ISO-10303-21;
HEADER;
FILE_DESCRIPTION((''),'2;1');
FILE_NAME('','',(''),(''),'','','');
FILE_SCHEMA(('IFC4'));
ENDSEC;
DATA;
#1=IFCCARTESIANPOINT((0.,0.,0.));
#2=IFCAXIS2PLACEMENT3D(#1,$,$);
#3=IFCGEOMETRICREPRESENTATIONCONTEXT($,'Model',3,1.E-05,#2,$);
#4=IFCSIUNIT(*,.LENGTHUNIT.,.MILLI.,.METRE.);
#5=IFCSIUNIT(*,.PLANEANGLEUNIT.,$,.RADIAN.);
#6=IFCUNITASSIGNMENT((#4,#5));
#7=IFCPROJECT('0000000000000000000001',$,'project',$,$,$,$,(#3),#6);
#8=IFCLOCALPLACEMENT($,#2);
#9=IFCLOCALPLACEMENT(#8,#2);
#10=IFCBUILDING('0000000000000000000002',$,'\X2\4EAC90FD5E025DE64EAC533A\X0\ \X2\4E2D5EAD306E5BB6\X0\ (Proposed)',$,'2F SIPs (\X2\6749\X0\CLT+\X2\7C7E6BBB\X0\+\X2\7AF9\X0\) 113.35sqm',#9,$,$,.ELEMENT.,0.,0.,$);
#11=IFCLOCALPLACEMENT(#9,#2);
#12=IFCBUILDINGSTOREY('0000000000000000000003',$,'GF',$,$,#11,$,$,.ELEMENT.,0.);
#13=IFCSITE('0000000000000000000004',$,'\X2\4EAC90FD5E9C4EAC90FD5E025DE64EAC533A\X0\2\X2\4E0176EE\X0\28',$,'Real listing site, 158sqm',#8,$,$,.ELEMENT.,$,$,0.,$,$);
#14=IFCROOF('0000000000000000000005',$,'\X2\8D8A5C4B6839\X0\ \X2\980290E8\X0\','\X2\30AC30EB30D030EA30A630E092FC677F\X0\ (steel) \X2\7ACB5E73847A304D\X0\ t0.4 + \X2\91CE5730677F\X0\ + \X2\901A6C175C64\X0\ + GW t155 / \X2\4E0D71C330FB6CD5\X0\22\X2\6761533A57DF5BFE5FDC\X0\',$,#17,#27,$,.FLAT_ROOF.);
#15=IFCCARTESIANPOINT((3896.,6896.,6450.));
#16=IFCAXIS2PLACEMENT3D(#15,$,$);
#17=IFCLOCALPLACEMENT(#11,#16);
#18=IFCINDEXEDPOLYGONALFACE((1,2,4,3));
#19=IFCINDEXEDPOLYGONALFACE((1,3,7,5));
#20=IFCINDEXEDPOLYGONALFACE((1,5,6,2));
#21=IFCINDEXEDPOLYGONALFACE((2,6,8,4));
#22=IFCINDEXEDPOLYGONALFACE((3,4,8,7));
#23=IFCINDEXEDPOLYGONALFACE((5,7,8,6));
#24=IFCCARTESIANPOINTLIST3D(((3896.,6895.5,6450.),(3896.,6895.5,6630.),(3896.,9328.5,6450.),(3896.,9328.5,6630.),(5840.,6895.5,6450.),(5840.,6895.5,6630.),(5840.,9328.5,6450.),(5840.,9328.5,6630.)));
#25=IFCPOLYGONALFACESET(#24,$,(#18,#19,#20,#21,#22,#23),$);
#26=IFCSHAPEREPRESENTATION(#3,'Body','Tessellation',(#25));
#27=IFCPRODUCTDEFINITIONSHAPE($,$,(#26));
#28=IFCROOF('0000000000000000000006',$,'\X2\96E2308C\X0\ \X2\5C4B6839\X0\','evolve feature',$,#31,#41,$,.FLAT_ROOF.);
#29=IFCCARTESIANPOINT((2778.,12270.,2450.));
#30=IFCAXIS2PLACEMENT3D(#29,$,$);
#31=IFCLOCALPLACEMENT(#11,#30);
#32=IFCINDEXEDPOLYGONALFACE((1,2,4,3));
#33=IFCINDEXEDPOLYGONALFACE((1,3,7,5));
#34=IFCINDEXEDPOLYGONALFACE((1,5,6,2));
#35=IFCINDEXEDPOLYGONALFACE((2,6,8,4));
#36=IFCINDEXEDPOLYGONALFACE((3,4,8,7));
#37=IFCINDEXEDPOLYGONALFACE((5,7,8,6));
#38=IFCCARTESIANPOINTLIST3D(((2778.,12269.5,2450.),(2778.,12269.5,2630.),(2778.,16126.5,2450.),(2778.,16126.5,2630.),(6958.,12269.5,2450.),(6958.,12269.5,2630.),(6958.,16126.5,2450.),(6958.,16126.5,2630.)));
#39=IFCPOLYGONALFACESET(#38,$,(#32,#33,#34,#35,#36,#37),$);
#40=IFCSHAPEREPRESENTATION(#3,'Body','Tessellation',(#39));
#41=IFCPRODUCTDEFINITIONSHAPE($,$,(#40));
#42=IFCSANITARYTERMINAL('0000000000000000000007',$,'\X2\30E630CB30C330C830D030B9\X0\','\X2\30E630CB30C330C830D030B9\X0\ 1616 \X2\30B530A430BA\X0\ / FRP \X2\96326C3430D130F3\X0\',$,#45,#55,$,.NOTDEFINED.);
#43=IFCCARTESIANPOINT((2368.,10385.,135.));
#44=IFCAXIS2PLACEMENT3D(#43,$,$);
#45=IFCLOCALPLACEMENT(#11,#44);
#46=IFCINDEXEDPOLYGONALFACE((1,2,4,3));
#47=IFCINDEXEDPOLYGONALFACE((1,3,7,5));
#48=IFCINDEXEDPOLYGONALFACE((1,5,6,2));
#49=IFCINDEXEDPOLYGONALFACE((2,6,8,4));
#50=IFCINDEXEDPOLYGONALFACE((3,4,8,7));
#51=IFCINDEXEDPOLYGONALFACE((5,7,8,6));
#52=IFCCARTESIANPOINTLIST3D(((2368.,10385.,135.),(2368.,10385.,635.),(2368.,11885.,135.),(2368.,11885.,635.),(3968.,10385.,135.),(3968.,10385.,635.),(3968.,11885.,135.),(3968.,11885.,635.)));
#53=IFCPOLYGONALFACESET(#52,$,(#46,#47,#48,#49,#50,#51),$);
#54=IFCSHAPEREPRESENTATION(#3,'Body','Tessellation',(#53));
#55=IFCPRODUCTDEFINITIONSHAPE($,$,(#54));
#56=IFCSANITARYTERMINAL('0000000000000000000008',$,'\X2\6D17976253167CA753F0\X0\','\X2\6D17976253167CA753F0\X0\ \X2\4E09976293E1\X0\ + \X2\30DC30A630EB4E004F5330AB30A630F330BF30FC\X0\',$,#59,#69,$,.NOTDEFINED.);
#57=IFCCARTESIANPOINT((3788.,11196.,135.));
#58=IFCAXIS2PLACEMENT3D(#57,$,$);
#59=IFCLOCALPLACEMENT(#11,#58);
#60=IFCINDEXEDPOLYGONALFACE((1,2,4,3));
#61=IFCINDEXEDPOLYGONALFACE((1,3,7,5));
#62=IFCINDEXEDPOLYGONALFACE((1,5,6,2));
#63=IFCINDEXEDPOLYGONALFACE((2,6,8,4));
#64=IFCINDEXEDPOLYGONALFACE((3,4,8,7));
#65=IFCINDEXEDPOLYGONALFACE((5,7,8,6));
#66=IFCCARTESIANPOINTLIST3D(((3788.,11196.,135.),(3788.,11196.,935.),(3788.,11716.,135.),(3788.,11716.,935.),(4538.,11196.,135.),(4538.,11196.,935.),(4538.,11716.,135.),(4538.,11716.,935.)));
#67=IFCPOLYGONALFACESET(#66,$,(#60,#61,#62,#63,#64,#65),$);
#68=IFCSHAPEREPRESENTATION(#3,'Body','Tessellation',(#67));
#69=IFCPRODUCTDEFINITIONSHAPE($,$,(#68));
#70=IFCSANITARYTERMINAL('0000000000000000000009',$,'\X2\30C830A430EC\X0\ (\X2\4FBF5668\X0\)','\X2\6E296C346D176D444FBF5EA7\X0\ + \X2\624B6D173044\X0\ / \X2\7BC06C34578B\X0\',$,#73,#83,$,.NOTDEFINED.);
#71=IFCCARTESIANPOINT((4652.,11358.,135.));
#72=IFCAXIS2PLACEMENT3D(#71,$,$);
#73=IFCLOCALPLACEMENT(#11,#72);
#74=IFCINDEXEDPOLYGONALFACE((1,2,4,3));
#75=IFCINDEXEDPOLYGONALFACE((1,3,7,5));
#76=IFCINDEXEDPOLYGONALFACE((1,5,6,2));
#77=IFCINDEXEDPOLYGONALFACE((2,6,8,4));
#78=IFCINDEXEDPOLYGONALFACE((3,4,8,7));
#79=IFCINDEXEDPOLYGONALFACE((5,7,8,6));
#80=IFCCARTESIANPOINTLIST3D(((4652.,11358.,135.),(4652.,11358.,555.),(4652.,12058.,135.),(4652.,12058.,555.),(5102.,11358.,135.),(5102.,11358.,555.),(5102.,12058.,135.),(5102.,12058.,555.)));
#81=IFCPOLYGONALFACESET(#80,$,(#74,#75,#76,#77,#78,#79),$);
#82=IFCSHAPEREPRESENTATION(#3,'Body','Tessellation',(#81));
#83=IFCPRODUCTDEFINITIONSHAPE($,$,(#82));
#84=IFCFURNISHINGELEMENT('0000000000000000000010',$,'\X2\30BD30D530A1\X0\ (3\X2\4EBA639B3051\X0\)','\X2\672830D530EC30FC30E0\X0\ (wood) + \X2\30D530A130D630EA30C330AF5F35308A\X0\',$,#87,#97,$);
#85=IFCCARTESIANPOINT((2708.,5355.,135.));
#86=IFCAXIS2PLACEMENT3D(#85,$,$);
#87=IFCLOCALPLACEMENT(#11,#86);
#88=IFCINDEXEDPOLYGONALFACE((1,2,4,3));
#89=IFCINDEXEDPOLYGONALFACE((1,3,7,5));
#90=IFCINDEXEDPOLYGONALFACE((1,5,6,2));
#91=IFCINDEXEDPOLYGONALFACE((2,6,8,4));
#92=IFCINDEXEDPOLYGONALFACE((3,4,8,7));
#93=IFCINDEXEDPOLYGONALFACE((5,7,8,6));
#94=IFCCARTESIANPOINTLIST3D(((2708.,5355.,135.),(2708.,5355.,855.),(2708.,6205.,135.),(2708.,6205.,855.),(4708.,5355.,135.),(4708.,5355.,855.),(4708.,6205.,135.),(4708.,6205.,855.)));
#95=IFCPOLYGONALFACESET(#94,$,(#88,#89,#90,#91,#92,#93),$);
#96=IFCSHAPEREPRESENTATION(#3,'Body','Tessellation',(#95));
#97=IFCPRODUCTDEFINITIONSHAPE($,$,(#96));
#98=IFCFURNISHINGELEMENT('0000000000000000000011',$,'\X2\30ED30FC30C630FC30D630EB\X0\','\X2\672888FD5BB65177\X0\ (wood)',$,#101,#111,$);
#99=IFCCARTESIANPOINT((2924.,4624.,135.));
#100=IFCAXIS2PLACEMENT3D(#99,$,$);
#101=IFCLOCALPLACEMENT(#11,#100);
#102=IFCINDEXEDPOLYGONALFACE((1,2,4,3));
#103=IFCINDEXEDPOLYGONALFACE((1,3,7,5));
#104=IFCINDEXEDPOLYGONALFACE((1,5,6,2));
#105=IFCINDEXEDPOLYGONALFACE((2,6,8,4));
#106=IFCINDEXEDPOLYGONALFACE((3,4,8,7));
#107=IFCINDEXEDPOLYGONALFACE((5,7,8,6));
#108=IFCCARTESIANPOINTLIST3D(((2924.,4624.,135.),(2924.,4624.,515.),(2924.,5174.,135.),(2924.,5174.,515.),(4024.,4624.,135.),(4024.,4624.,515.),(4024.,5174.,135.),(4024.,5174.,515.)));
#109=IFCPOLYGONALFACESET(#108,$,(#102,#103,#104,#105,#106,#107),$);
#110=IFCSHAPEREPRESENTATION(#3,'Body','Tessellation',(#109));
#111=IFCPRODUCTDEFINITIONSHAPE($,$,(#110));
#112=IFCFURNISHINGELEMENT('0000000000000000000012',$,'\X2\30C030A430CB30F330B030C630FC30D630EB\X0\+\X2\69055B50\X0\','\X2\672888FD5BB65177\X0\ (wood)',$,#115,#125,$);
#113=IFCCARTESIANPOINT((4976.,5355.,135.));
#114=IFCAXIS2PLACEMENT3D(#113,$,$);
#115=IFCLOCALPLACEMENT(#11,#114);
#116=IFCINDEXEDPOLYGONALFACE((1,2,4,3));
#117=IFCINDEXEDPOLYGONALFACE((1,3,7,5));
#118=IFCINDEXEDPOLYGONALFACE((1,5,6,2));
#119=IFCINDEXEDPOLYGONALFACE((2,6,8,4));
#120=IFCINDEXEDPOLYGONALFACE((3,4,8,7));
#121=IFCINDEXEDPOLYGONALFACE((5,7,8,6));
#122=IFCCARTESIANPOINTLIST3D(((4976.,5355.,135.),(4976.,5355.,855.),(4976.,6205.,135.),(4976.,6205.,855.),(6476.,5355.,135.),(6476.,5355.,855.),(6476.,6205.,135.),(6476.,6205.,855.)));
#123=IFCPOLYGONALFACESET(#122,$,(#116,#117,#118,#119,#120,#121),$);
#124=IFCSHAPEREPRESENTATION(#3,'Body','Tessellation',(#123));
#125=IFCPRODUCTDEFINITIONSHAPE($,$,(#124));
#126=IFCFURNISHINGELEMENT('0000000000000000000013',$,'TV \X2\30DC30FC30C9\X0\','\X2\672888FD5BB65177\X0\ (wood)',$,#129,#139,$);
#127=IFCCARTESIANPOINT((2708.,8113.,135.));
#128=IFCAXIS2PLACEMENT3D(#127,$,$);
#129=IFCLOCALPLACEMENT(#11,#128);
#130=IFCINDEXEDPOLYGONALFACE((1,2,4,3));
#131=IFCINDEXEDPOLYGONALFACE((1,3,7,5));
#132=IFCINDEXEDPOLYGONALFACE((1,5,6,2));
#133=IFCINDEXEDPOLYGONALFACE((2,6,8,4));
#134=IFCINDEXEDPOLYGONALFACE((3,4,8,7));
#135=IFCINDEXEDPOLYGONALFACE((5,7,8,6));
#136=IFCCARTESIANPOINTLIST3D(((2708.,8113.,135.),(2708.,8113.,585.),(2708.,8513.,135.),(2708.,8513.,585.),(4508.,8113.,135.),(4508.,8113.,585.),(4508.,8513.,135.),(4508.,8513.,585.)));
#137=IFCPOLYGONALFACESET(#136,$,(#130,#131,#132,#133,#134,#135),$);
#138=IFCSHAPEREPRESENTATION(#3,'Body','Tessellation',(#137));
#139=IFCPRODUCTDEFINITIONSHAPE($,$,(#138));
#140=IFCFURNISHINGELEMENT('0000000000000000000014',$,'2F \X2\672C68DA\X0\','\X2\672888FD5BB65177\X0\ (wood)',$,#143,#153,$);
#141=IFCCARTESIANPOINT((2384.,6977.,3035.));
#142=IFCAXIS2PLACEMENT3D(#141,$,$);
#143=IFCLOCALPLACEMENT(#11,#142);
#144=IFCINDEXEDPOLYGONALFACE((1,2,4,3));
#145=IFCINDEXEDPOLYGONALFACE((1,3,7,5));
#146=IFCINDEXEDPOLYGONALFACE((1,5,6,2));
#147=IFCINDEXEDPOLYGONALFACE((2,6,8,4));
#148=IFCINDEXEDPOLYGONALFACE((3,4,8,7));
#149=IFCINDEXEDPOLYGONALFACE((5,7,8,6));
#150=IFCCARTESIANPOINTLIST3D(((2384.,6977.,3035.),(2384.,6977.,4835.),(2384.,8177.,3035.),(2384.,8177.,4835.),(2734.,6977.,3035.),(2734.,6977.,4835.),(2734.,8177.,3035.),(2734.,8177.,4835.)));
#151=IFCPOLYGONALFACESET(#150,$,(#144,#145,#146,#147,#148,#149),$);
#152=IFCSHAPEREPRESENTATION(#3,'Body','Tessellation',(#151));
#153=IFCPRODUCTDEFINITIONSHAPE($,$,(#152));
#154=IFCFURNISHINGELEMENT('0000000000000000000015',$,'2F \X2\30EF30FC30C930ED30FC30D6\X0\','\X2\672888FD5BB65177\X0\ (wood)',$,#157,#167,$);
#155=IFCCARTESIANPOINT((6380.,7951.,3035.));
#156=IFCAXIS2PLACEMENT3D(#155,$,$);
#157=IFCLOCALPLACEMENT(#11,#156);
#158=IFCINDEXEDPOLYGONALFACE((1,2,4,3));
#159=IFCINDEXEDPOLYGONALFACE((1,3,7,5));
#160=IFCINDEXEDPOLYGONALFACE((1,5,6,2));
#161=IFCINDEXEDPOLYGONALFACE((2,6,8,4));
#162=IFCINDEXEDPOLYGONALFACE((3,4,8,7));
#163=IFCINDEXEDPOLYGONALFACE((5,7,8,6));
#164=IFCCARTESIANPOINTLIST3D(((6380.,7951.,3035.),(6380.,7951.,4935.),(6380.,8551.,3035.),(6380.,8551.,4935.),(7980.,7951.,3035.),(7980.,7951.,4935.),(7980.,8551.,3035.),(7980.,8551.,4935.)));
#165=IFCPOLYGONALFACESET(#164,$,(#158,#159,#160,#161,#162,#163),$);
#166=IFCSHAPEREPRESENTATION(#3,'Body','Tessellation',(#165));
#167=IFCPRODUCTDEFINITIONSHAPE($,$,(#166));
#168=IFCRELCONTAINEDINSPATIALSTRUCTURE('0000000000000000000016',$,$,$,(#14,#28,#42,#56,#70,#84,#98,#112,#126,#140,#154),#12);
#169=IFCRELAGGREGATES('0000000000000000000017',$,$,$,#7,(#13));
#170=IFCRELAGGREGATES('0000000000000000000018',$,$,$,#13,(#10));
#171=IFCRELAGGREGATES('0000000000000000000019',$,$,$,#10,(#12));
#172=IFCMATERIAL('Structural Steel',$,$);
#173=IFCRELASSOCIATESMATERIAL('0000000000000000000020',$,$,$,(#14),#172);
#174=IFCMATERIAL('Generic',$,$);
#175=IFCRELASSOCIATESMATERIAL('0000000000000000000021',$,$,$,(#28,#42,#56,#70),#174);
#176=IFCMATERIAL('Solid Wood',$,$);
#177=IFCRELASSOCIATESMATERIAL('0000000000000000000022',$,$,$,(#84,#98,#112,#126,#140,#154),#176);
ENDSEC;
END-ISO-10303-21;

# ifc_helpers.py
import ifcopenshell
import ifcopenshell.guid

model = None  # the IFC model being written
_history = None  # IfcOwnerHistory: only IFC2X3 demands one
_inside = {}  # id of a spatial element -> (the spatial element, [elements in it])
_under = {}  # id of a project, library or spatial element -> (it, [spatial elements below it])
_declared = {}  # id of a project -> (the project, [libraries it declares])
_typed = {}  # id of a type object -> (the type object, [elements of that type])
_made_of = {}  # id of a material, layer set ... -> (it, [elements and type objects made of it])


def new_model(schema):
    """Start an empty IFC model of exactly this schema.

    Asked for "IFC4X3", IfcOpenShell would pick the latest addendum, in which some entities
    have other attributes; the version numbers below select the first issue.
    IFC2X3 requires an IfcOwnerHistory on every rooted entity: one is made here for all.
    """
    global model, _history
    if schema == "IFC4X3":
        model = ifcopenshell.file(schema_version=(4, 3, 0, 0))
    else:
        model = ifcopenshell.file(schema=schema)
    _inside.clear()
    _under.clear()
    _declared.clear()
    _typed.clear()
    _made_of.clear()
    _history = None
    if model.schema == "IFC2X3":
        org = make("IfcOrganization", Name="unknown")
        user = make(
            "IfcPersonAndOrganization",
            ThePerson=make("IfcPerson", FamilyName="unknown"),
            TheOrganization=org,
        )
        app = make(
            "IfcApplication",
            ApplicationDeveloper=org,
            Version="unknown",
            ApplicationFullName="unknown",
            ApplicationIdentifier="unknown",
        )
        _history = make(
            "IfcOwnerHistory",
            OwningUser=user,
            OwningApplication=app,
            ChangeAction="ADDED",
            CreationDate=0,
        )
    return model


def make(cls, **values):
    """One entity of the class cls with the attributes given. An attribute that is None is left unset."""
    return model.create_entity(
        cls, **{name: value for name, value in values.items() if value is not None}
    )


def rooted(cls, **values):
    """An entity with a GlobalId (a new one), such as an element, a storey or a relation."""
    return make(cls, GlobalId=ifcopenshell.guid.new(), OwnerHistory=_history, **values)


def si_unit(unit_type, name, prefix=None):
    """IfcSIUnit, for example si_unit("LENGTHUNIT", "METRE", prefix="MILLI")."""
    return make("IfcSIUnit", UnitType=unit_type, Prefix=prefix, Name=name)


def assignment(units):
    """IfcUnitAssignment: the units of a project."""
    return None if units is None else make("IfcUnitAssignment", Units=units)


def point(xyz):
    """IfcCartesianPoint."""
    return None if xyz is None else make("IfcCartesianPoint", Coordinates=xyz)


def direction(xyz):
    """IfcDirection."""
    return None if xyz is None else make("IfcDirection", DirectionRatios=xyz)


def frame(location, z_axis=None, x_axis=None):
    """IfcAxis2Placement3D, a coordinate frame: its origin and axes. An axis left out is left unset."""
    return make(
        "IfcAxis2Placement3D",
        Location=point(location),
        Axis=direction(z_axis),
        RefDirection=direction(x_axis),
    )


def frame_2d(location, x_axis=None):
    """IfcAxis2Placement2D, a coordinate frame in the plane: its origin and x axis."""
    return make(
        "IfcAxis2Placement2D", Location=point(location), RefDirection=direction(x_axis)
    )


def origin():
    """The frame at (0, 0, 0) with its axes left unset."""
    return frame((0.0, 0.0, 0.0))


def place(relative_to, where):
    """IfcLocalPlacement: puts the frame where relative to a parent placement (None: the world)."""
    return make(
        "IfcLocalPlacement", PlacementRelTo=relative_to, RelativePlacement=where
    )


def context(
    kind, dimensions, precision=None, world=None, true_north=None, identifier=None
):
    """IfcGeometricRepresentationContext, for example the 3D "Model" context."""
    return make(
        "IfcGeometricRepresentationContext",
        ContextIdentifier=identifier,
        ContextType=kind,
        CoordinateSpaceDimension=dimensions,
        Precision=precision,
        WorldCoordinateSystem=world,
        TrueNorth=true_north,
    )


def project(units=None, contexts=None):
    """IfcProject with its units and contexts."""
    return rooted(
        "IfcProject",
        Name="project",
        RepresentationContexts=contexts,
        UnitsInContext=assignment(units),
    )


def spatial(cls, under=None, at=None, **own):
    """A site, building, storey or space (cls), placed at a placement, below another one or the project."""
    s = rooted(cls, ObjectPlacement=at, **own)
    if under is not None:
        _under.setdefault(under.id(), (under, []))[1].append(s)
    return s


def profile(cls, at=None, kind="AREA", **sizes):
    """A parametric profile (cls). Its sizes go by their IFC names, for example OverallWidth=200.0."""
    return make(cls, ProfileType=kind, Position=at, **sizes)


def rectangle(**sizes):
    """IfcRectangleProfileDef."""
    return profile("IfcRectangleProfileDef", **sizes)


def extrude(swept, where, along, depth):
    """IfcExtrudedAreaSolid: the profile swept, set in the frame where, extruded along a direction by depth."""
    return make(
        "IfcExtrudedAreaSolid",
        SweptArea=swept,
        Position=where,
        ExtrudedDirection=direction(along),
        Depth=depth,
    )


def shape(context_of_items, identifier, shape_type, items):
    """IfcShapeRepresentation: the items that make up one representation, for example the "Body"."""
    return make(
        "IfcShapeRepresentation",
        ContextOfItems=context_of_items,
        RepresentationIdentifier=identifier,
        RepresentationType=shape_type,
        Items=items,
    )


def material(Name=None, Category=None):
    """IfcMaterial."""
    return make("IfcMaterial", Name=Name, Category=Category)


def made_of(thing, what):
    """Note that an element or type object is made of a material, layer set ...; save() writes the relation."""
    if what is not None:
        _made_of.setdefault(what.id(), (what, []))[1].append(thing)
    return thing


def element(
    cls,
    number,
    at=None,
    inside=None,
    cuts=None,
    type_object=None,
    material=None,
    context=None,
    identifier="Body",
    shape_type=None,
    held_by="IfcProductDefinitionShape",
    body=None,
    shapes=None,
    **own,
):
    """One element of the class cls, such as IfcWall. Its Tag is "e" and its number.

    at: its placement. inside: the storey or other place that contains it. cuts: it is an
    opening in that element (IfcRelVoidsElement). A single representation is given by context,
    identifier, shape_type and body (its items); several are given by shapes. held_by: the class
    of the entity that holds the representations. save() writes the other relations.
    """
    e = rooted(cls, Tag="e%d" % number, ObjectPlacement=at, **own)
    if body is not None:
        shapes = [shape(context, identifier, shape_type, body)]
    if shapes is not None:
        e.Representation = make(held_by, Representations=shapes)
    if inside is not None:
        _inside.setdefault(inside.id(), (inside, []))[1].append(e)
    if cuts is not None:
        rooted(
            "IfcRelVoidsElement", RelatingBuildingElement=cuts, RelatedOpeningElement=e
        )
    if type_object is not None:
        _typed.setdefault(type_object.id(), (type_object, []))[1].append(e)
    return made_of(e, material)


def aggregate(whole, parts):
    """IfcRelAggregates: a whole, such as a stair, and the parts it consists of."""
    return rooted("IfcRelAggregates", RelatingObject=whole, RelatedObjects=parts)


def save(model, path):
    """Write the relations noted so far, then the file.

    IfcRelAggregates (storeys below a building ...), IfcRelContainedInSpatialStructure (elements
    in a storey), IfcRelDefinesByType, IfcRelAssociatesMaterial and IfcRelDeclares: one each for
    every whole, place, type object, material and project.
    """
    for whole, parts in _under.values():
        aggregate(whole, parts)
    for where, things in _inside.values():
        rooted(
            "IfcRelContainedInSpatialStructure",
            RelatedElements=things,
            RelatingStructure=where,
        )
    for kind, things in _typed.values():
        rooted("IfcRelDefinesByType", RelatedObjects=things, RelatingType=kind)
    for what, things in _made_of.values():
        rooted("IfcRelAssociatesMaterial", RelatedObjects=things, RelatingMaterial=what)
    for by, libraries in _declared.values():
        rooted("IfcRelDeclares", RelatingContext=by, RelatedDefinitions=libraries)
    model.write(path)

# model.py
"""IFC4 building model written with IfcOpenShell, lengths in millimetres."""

from ifc_helpers import new_model, si_unit, frame, frame_2d, origin, place, context, project, spatial, rectangle, extrude, material, element, save


model = new_model("IFC4")

# Units and contexts
model_context = context("Model", 3, precision=1e-05, world=origin())
ifc_project = project(units=[si_unit("LENGTHUNIT", "METRE", prefix="MILLI"), si_unit("PLANEANGLEUNIT", "RADIAN")], contexts=[model_context])

# Site, building, storey
site_placement = place(None, origin())
site = spatial("IfcSite", under=ifc_project, at=site_placement, Name="京都府京都市左京区2丁目28", ObjectType="Real listing site, 158sqm", CompositionType="ELEMENT", RefElevation=0.0)
building_placement = place(site_placement, origin())
building = spatial("IfcBuilding", under=site, at=building_placement, Name="京都市左京区 中庭の家 (Proposed)", ObjectType="2F SIPs (杉CLT+籾殻+竹) 113.35sqm", CompositionType="ELEMENT", ElevationOfRefHeight=0.0, ElevationOfTerrain=0.0)
storey_placement = place(building_placement, origin())
storey = spatial("IfcBuildingStorey", under=building, at=storey_placement, Name="GF", CompositionType="ELEMENT", Elevation=0.0)

# Shared definitions
ifc_material_1 = material(Name="Generic")

# Shared definitions
ifc_material_2 = material(Name="Solid Wood")

# Roofs
ifc_material_3 = material(Name="Structural Steel")
roof_1_placement = place(storey_placement, frame((3896.0, 6896.0, 6450.0)))
element("IfcRoof", 1, at=roof_1_placement, inside=storey, material=ifc_material_3, Name="越屋根 頂部", Description="ガルバリウム鋼板 (steel) 立平葺き t0.4 + 野地板 + 通気層 + GW t155 / 不燃・法22条区域対応", PredefinedType="FLAT_ROOF", context=model_context, shape_type="SweptSolid", body=[
    extrude(rectangle(XDim=1944.0, YDim=2433.0, at=frame_2d((972.0, 1216.0))), frame((3896.0, 6896.0, 6450.0)), (0.0, 0.0, 1.0), 180.0),
])
roof_2_placement = place(storey_placement, frame((2778.0, 12270.0, 2450.0)))
element("IfcRoof", 2, at=roof_2_placement, inside=storey, material=ifc_material_1, Name="離れ 屋根", Description="evolve feature", PredefinedType="FLAT_ROOF", context=model_context, shape_type="SweptSolid", body=[
    extrude(rectangle(XDim=4180.0, YDim=3857.0, at=frame_2d((2090.0, 1928.0))), frame((2778.0, 12270.0, 2450.0)), (0.0, 0.0, 1.0), 180.0),
])

# Sanitary terminals
sanitary_terminal_1_placement = place(storey_placement, frame((2368.0, 10385.0, 135.0)))
element("IfcSanitaryTerminal", 3, at=sanitary_terminal_1_placement, inside=storey, material=ifc_material_1, Name="ユニットバス", Description="ユニットバス 1616 サイズ / FRP 防水パン", PredefinedType="NOTDEFINED", context=model_context, shape_type="SweptSolid", body=[
    extrude(rectangle(XDim=1600.0, YDim=1500.0, at=frame_2d((800.0, 750.0))), frame((2368.0, 10385.0, 135.0)), (0.0, 0.0, 1.0), 500.0),
])
sanitary_terminal_2_placement = place(storey_placement, frame((3788.0, 11196.0, 135.0)))
element("IfcSanitaryTerminal", 4, at=sanitary_terminal_2_placement, inside=storey, material=ifc_material_1, Name="洗面化粧台", Description="洗面化粧台 三面鏡 + ボウル一体カウンター", PredefinedType="NOTDEFINED", context=model_context, shape_type="SweptSolid", body=[
    extrude(rectangle(XDim=750.0, YDim=520.0, at=frame_2d((375.0, 260.0))), frame((3788.0, 11196.0, 135.0)), (0.0, 0.0, 1.0), 800.0),
])
sanitary_terminal_3_placement = place(storey_placement, frame((4652.0, 11358.0, 135.0)))
element("IfcSanitaryTerminal", 5, at=sanitary_terminal_3_placement, inside=storey, material=ifc_material_1, Name="トイレ (便器)", Description="温水洗浄便座 + 手洗い / 節水型", PredefinedType="NOTDEFINED", context=model_context, shape_type="SweptSolid", body=[
    extrude(rectangle(XDim=450.0, YDim=700.0, at=frame_2d((225.0, 350.0))), frame((4652.0, 11358.0, 135.0)), (0.0, 0.0, 1.0), 420.0),
])

# Furnishing elements
furnishing_1_placement = place(storey_placement, frame((2708.0, 5355.0, 135.0)))
element("IfcFurnishingElement", 6, at=furnishing_1_placement, inside=storey, material=ifc_material_2, Name="ソファ (3人掛け)", Description="木フレーム (wood) + ファブリック張り", context=model_context, shape_type="SweptSolid", body=[
    extrude(rectangle(XDim=2000.0, YDim=850.0, at=frame_2d((1000.0, 425.0))), frame((2708.0, 5355.0, 135.0)), (0.0, 0.0, 1.0), 720.0),
])
furnishing_2_placement = place(storey_placement, frame((2924.0, 4624.0, 135.0)))
element("IfcFurnishingElement", 7, at=furnishing_2_placement, inside=storey, material=ifc_material_2, Name="ローテーブル", Description="木製家具 (wood)", context=model_context, shape_type="SweptSolid", body=[
    extrude(rectangle(XDim=1100.0, YDim=550.0, at=frame_2d((550.0, 275.0))), frame((2924.0, 4624.0, 135.0)), (0.0, 0.0, 1.0), 380.0),
])
furnishing_3_placement = place(storey_placement, frame((4976.0, 5355.0, 135.0)))
element("IfcFurnishingElement", 8, at=furnishing_3_placement, inside=storey, material=ifc_material_2, Name="ダイニングテーブル+椅子", Description="木製家具 (wood)", context=model_context, shape_type="SweptSolid", body=[
    extrude(rectangle(XDim=1500.0, YDim=850.0, at=frame_2d((750.0, 425.0))), frame((4976.0, 5355.0, 135.0)), (0.0, 0.0, 1.0), 720.0),
])
furnishing_4_placement = place(storey_placement, frame((2708.0, 8113.0, 135.0)))
element("IfcFurnishingElement", 9, at=furnishing_4_placement, inside=storey, material=ifc_material_2, Name="TV ボード", Description="木製家具 (wood)", context=model_context, shape_type="SweptSolid", body=[
    extrude(rectangle(XDim=1800.0, YDim=400.0, at=frame_2d((900.0, 200.0))), frame((2708.0, 8113.0, 135.0)), (0.0, 0.0, 1.0), 450.0),
])
furnishing_5_placement = place(storey_placement, frame((2384.0, 6977.0, 3035.0)))
element("IfcFurnishingElement", 10, at=furnishing_5_placement, inside=storey, material=ifc_material_2, Name="2F 本棚", Description="木製家具 (wood)", context=model_context, shape_type="SweptSolid", body=[
    extrude(rectangle(XDim=350.0, YDim=1200.0, at=frame_2d((175.0, 600.0))), frame((2384.0, 6977.0, 3035.0)), (0.0, 0.0, 1.0), 1800.0),
])
furnishing_6_placement = place(storey_placement, frame((6380.0, 7951.0, 3035.0)))
element("IfcFurnishingElement", 11, at=furnishing_6_placement, inside=storey, material=ifc_material_2, Name="2F ワードローブ", Description="木製家具 (wood)", context=model_context, shape_type="SweptSolid", body=[
    extrude(rectangle(XDim=1600.0, YDim=600.0, at=frame_2d((800.0, 300.0))), frame((6380.0, 7951.0, 3035.0)), (0.0, 0.0, 1.0), 1900.0),
])

save(model, "model.ifc")
